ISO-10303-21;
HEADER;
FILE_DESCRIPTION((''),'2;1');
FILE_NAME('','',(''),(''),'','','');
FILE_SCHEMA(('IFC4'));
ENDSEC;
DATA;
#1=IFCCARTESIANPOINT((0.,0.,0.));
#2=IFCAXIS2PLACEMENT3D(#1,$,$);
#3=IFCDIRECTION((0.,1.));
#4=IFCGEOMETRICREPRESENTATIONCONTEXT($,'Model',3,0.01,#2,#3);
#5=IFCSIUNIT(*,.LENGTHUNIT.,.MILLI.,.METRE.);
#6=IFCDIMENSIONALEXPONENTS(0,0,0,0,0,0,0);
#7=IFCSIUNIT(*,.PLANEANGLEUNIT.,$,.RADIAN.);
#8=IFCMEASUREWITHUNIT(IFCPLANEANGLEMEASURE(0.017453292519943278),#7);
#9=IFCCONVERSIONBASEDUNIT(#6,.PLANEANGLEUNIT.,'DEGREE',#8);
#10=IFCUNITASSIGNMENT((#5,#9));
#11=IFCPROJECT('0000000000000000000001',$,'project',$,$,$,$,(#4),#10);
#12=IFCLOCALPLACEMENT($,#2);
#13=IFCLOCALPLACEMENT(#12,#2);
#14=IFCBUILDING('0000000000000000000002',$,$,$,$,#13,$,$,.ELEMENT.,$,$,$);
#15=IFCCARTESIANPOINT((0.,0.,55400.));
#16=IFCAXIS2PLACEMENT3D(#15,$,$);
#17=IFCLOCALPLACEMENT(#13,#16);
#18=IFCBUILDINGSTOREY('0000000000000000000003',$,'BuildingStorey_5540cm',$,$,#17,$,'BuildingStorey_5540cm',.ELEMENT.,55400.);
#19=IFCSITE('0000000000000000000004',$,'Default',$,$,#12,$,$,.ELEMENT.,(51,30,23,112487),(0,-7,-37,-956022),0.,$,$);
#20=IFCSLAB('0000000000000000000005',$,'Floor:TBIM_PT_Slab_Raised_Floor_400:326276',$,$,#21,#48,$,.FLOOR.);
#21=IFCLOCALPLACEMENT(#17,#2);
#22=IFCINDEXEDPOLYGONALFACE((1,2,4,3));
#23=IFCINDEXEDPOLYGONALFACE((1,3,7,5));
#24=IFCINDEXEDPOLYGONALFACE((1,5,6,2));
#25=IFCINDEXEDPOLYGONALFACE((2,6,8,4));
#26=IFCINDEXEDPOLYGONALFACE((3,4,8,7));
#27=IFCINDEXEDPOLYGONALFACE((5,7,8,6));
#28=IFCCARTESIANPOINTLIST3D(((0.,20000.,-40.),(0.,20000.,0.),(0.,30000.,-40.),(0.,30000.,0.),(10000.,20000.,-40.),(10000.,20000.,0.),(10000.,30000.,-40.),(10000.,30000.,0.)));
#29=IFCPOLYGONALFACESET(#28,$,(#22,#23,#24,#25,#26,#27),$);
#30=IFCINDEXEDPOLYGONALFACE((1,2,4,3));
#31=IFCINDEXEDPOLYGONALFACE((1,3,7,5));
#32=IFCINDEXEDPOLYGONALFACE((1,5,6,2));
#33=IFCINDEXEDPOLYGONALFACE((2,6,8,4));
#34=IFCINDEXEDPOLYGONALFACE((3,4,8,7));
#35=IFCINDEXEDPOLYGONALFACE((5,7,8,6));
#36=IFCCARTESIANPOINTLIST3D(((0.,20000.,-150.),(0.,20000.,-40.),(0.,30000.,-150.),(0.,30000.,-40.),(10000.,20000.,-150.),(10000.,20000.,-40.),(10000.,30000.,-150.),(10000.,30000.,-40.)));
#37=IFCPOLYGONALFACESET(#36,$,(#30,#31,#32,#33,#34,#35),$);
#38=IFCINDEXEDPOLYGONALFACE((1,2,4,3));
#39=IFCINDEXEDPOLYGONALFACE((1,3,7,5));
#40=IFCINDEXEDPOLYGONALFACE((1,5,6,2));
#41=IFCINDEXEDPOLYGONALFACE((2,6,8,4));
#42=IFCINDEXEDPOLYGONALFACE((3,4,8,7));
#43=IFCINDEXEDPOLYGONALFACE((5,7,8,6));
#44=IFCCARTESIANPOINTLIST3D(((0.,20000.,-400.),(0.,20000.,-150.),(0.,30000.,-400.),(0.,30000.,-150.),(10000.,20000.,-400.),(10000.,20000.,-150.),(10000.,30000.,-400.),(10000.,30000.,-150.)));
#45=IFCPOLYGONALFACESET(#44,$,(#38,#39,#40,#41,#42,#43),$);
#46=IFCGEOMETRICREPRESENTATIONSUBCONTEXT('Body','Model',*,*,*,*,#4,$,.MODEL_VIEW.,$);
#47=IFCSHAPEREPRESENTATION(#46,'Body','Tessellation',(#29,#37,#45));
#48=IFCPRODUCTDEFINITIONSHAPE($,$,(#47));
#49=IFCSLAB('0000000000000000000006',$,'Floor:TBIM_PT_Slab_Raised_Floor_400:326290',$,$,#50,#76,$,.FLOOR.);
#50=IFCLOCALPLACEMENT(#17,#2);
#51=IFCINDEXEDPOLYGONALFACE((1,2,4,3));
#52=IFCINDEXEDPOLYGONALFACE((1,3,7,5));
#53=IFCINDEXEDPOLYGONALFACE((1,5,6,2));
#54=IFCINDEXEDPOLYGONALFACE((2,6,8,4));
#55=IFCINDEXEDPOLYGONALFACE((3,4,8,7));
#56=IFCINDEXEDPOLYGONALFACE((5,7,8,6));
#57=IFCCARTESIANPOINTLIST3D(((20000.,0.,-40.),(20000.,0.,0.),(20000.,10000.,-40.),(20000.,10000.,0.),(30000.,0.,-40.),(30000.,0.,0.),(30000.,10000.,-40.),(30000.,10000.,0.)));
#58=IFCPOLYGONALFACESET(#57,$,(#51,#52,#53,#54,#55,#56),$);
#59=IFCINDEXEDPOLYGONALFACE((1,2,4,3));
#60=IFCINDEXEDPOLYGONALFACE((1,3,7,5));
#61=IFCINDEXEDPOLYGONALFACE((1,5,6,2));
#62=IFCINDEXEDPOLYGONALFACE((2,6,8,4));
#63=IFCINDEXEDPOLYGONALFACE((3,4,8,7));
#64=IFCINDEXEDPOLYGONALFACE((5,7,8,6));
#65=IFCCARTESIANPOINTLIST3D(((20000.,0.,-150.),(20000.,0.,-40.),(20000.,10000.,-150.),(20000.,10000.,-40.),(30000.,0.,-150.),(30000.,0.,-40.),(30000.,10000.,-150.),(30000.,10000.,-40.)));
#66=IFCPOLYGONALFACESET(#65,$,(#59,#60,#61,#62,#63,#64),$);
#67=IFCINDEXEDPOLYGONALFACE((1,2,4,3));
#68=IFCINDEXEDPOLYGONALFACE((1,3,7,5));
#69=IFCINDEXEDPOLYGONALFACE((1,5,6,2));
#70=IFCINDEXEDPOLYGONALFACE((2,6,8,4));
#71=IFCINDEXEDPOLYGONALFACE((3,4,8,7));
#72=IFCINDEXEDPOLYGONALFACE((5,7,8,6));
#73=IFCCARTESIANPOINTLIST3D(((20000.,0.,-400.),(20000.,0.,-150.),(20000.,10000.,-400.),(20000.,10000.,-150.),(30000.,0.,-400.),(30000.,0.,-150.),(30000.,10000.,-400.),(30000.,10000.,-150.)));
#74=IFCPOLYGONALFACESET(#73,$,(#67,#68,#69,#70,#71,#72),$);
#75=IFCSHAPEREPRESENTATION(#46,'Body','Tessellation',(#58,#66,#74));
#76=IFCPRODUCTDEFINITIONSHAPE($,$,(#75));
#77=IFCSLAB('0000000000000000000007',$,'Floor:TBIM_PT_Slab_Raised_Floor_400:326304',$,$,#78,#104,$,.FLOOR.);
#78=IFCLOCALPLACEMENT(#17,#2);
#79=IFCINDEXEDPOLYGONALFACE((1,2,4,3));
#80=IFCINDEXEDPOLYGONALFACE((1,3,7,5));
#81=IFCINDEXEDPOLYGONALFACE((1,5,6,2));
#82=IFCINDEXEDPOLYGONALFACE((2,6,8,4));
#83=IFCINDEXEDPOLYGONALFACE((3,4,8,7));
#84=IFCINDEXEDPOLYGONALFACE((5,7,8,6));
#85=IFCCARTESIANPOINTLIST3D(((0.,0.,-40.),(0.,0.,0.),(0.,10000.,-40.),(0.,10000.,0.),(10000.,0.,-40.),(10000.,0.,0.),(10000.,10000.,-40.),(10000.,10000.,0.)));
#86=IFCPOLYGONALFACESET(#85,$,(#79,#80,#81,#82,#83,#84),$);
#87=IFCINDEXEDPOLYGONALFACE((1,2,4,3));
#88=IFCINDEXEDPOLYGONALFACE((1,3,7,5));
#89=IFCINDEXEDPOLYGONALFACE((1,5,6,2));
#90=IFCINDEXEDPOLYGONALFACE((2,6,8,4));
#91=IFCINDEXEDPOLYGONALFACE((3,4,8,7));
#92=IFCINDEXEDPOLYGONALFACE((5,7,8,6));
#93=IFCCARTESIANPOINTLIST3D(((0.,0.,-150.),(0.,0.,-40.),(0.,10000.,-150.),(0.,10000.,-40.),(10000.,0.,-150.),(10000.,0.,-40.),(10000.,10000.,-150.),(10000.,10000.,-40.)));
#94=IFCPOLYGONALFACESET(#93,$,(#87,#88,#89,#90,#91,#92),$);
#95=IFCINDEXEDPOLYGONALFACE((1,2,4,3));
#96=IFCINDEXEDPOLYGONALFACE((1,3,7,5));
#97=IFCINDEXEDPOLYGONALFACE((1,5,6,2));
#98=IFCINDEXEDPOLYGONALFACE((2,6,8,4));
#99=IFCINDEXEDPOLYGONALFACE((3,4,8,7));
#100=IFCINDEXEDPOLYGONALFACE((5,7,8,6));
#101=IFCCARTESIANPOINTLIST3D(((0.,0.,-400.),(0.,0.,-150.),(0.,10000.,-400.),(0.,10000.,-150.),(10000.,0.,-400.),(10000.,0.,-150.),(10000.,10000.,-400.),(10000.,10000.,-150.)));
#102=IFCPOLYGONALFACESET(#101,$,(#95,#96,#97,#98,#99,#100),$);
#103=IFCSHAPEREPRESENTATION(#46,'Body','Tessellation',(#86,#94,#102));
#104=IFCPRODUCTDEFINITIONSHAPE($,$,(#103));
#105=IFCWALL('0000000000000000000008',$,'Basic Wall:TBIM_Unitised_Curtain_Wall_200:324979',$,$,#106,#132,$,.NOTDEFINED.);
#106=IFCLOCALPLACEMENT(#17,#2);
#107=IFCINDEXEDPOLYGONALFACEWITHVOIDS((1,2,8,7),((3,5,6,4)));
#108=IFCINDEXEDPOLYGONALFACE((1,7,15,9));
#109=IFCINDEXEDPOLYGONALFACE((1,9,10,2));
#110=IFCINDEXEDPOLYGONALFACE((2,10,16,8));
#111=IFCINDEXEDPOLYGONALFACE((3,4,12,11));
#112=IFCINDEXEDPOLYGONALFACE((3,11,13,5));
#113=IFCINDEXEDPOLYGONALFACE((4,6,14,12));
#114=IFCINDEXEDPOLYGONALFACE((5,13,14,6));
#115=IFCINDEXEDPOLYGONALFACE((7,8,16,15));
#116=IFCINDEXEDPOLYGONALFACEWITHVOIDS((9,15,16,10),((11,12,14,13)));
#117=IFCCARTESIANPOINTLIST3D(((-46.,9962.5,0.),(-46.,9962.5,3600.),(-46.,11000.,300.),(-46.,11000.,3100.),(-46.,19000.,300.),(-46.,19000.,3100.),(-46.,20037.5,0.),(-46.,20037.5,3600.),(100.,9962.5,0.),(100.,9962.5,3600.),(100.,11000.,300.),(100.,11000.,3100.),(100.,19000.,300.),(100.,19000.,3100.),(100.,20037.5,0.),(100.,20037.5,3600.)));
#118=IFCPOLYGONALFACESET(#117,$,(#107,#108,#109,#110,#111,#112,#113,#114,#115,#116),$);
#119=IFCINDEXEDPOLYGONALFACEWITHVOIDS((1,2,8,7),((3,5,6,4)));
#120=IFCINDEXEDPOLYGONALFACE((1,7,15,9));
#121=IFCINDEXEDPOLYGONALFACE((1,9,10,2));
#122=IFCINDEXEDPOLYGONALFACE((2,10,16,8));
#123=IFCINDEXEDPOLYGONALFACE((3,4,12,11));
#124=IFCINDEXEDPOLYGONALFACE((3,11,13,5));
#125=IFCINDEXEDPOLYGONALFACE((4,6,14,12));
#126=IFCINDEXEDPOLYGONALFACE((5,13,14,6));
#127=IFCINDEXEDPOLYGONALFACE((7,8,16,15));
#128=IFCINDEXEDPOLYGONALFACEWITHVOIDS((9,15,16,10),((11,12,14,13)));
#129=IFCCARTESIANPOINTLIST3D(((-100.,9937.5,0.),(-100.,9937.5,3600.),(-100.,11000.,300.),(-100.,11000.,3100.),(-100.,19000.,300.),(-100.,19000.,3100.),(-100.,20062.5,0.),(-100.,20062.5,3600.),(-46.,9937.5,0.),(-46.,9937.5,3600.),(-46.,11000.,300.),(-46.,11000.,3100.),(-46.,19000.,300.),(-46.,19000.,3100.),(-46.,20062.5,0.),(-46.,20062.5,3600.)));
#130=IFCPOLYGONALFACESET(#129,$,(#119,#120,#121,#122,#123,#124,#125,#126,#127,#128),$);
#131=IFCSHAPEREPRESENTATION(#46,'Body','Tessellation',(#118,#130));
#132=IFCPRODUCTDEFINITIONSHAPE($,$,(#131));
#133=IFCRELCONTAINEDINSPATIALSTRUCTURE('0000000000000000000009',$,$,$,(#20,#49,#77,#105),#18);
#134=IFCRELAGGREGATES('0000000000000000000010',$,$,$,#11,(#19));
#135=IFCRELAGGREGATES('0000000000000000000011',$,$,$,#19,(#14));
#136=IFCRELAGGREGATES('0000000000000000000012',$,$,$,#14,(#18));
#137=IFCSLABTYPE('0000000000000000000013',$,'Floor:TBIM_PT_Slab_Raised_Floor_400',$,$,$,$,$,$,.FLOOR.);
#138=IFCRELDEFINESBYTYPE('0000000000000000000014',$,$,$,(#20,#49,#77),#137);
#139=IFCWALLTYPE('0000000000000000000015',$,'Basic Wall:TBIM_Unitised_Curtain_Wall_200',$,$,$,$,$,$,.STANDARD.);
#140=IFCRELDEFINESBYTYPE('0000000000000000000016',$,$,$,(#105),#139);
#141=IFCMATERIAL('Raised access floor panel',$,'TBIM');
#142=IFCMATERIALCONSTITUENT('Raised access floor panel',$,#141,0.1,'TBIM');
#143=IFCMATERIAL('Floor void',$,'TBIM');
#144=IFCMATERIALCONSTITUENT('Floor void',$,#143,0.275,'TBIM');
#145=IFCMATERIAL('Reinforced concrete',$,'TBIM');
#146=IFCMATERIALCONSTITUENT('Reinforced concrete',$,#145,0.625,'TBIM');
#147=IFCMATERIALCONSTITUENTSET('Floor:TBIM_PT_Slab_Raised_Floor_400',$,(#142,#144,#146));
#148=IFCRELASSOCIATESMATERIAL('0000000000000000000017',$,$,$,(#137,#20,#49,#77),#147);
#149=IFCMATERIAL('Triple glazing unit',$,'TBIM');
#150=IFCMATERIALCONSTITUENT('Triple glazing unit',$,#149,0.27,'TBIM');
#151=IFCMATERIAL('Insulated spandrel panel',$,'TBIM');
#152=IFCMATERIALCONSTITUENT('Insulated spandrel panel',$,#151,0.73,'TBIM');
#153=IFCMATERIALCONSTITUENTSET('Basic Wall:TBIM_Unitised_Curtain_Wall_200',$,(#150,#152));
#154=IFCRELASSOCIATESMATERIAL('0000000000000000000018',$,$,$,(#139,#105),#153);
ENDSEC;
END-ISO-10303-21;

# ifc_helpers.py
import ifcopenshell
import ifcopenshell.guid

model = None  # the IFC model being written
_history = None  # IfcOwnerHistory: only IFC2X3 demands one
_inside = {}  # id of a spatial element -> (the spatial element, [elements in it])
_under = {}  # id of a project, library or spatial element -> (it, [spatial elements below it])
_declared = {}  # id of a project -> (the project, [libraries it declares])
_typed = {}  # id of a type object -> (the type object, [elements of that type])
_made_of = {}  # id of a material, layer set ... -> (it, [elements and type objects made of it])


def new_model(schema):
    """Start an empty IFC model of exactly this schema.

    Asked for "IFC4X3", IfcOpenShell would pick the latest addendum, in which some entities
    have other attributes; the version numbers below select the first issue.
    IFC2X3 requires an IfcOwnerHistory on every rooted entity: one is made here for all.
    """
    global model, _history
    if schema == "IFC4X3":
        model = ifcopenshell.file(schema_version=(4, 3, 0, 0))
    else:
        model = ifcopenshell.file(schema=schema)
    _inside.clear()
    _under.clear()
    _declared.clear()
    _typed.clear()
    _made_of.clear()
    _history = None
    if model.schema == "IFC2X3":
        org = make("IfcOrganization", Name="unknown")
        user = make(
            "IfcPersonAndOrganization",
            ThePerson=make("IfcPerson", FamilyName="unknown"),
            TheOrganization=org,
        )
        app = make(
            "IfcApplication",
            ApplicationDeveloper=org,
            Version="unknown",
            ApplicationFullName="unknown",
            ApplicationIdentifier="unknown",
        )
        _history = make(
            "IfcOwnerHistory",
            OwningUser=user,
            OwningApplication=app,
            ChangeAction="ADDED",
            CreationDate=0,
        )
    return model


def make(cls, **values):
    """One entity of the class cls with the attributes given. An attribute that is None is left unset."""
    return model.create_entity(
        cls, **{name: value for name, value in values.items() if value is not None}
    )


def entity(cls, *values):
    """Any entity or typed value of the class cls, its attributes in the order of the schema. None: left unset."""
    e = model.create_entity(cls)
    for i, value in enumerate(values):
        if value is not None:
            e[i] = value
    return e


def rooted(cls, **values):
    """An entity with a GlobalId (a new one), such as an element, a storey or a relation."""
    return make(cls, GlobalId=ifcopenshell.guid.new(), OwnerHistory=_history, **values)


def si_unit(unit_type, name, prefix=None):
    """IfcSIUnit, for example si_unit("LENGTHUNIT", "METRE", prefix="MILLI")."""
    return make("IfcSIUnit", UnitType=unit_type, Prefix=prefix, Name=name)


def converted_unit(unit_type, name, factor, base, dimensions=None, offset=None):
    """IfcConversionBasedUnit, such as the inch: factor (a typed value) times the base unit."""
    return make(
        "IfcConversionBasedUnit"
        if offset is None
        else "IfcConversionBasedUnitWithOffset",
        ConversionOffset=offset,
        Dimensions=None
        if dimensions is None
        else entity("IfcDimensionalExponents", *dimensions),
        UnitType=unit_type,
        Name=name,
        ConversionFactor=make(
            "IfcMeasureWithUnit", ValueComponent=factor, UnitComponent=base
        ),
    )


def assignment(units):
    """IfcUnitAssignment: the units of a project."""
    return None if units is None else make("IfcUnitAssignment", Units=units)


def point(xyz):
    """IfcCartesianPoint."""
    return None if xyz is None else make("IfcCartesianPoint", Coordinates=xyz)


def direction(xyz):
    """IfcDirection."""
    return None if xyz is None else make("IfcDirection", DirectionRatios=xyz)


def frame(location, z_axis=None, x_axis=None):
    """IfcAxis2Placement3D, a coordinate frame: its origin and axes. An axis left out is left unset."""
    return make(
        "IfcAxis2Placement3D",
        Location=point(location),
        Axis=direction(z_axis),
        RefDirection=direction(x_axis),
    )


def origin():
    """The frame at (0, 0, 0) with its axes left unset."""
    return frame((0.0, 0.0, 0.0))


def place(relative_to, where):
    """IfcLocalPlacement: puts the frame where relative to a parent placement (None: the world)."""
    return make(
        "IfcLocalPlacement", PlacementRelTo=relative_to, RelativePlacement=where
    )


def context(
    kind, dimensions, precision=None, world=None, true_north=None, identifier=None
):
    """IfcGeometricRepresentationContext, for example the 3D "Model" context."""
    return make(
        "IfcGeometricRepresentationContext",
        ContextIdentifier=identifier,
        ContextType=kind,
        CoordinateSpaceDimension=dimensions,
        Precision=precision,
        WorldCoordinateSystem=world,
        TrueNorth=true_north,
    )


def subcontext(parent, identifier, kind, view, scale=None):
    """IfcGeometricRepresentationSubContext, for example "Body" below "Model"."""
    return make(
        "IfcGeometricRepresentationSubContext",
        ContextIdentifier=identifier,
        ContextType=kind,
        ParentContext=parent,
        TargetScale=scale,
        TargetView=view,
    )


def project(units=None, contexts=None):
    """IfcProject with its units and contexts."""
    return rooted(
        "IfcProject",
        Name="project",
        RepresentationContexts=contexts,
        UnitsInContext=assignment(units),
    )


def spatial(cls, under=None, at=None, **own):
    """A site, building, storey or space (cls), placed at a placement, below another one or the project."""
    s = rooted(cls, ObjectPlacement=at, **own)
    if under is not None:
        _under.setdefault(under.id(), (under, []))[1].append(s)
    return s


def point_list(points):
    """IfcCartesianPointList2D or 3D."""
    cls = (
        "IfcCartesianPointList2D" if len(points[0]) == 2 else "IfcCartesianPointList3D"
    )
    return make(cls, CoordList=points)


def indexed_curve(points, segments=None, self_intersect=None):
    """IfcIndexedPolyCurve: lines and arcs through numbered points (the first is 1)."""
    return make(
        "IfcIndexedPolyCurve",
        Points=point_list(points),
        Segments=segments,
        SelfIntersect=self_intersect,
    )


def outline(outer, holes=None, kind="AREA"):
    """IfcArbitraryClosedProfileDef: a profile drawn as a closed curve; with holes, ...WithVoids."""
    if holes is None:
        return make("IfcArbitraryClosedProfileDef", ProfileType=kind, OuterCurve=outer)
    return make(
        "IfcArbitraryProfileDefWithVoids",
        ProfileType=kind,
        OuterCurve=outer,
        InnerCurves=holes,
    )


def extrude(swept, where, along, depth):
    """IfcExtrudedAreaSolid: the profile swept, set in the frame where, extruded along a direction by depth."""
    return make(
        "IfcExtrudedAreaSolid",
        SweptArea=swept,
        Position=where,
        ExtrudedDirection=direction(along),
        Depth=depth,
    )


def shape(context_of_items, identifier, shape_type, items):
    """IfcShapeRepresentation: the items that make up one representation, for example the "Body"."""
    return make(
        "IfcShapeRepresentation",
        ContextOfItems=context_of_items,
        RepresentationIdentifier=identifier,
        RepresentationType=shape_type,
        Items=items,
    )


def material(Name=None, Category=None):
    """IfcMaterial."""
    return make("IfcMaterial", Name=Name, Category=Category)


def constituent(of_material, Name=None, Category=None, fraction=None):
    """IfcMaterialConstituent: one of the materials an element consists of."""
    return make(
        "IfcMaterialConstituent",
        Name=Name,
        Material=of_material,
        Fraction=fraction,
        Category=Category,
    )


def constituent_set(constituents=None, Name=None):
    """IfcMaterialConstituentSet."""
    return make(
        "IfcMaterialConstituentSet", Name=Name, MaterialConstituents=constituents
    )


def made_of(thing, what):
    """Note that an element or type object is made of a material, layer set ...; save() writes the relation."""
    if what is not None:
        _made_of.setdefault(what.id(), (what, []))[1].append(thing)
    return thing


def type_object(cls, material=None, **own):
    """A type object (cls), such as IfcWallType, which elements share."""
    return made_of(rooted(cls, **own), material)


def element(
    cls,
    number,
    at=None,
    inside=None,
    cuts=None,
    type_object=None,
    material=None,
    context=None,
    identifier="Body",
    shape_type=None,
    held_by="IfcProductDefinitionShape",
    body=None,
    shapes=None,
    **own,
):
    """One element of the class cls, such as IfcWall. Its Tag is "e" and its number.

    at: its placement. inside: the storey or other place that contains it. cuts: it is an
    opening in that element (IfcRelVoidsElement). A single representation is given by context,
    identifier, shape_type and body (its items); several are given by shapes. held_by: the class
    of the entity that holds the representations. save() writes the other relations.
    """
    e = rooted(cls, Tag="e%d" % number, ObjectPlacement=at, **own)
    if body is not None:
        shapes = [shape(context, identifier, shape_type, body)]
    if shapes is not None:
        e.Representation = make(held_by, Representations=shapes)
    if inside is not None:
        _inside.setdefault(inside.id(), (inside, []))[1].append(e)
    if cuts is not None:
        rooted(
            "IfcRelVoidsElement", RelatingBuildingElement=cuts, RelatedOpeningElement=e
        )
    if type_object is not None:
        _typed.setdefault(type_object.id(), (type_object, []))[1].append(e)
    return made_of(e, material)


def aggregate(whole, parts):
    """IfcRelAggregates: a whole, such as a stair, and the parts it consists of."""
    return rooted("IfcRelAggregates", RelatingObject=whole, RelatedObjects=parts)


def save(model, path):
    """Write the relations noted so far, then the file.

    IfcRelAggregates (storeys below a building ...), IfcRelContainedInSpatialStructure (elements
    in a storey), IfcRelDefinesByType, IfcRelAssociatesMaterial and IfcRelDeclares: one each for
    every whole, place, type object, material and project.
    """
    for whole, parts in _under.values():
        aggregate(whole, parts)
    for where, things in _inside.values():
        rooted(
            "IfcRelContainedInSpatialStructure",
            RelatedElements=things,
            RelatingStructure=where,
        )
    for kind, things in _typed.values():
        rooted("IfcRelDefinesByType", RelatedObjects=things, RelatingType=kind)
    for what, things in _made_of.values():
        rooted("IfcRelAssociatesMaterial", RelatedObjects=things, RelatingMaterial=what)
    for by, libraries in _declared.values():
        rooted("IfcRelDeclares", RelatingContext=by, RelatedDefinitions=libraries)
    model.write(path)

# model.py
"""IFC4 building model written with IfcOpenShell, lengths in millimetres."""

from ifc_helpers import new_model, entity, si_unit, converted_unit, direction, frame, origin, place, context, subcontext, project, spatial, indexed_curve, outline, extrude, material, constituent, constituent_set, type_object, element, save


model = new_model("IFC4")

# Units and contexts
model_context = context("Model", 3, precision=0.01, world=origin(), true_north=direction((0.0, 1.0)))
body_context = subcontext(model_context, "Body", "Model", "MODEL_VIEW")
ifc_project = project(units=[si_unit("LENGTHUNIT", "METRE", prefix="MILLI"), converted_unit("PLANEANGLEUNIT", "DEGREE", entity("IfcPlaneAngleMeasure", 0.017453292519943278), si_unit("PLANEANGLEUNIT", "RADIAN"), dimensions=[0, 0, 0, 0, 0, 0, 0])], contexts=[model_context])

# Site, building, storey
site_placement = place(None, origin())
site = spatial("IfcSite", under=ifc_project, at=site_placement, Name="Default", CompositionType="ELEMENT", RefLatitude=(51, 30, 23, 112487), RefLongitude=(0, -7, -37, -956022), RefElevation=0.0)
building_placement = place(site_placement, origin())
building = spatial("IfcBuilding", under=site, at=building_placement, CompositionType="ELEMENT")
storey_placement = place(building_placement, frame((0.0, 0.0, 55400.0)))
storey = spatial("IfcBuildingStorey", under=building, at=storey_placement, Name="BuildingStorey_5540cm", LongName="BuildingStorey_5540cm", CompositionType="ELEMENT", Elevation=55400.0)

# Slabs
ifc_material_1 = material(Name="Raised access floor panel", Category="TBIM")
ifc_constituent_1 = constituent(ifc_material_1, Name="Raised access floor panel", Category="TBIM", fraction=0.1)
ifc_material_2 = material(Name="Floor void", Category="TBIM")
ifc_constituent_2 = constituent(ifc_material_2, Name="Floor void", Category="TBIM", fraction=0.275)
ifc_material_3 = material(Name="Reinforced concrete", Category="TBIM")
ifc_constituent_3 = constituent(ifc_material_3, Name="Reinforced concrete", Category="TBIM", fraction=0.625)
ifc_constituent_set_1 = constituent_set(constituents=[ifc_constituent_1, ifc_constituent_2, ifc_constituent_3], Name="Floor:TBIM_PT_Slab_Raised_Floor_400")
slab_type = type_object("IfcSlabType", Name="Floor:TBIM_PT_Slab_Raised_Floor_400", PredefinedType="FLOOR", material=ifc_constituent_set_1)
slab_1_placement = place(storey_placement, origin())
element("IfcSlab", 1, at=slab_1_placement, inside=storey, type_object=slab_type, material=ifc_constituent_set_1, Name="Floor:TBIM_PT_Slab_Raised_Floor_400:326276", PredefinedType="FLOOR", context=body_context, shape_type="SweptSolid", body=[
    extrude(outline(indexed_curve([(-5000.0, -5000.0), (5000.0, -5000.0), (5000.0, 5000.0), (-5000.0, 5000.0), (-5000.0, -5000.0)], self_intersect=False)), frame((5000.0, 25000.0, -40.0), z_axis=(0.0, 0.0, 1.0), x_axis=(-1.0, 0.0, 0.0)), (0.0, 0.0, 1.0), 40.0),
    extrude(outline(indexed_curve([(-5000.0, -5000.0), (5000.0, -5000.0), (5000.0, 5000.0), (-5000.0, 5000.0), (-5000.0, -5000.0)], self_intersect=False)), frame((5000.0, 25000.0, -150.0), z_axis=(0.0, 0.0, 1.0), x_axis=(-1.0, 0.0, 0.0)), (0.0, 0.0, 1.0), 110.0),
    extrude(outline(indexed_curve([(-5000.0, -5000.0), (5000.0, -5000.0), (5000.0, 5000.0), (-5000.0, 5000.0), (-5000.0, -5000.0)], self_intersect=False)), frame((5000.0, 25000.0, -400.0), z_axis=(0.0, 0.0, 1.0), x_axis=(-1.0, 0.0, 0.0)), (0.0, 0.0, 1.0), 250.0),
])
slab_2_placement = place(storey_placement, origin())
element("IfcSlab", 2, at=slab_2_placement, inside=storey, type_object=slab_type, material=ifc_constituent_set_1, Name="Floor:TBIM_PT_Slab_Raised_Floor_400:326290", PredefinedType="FLOOR", context=body_context, shape_type="SweptSolid", body=[
    extrude(outline(indexed_curve([(-5000.0, -5000.0), (5000.0, -5000.0), (5000.0, 5000.0), (-5000.0, 5000.0), (-5000.0, -5000.0)], self_intersect=False)), frame((25000.0, 5000.0, -40.0), z_axis=(0.0, 0.0, 1.0), x_axis=(-1.0, 0.0, 0.0)), (0.0, 0.0, 1.0), 40.0),
    extrude(outline(indexed_curve([(-5000.0, -5000.0), (5000.0, -5000.0), (5000.0, 5000.0), (-5000.0, 5000.0), (-5000.0, -5000.0)], self_intersect=False)), frame((25000.0, 5000.0, -150.0), z_axis=(0.0, 0.0, 1.0), x_axis=(-1.0, 0.0, 0.0)), (0.0, 0.0, 1.0), 110.0),
    extrude(outline(indexed_curve([(-5000.0, -5000.0), (5000.0, -5000.0), (5000.0, 5000.0), (-5000.0, 5000.0), (-5000.0, -5000.0)], self_intersect=False)), frame((25000.0, 5000.0, -400.0), z_axis=(0.0, 0.0, 1.0), x_axis=(-1.0, 0.0, 0.0)), (0.0, 0.0, 1.0), 250.0),
])
slab_3_placement = place(storey_placement, origin())
element("IfcSlab", 3, at=slab_3_placement, inside=storey, type_object=slab_type, material=ifc_constituent_set_1, Name="Floor:TBIM_PT_Slab_Raised_Floor_400:326304", PredefinedType="FLOOR", context=body_context, shape_type="SweptSolid", body=[
    extrude(outline(indexed_curve([(-5000.0, -5000.0), (5000.0, -5000.0), (5000.0, 5000.0), (-5000.0, 5000.0), (-5000.0, -5000.0)], self_intersect=False)), frame((5000.0, 5000.0, -40.0), z_axis=(0.0, 0.0, 1.0), x_axis=(-1.0, 0.0, 0.0)), (0.0, 0.0, 1.0), 40.0),
    extrude(outline(indexed_curve([(-5000.0, -5000.0), (5000.0, -5000.0), (5000.0, 5000.0), (-5000.0, 5000.0), (-5000.0, -5000.0)], self_intersect=False)), frame((5000.0, 5000.0, -150.0), z_axis=(0.0, 0.0, 1.0), x_axis=(-1.0, 0.0, 0.0)), (0.0, 0.0, 1.0), 110.0),
    extrude(outline(indexed_curve([(-5000.0, -5000.0), (5000.0, -5000.0), (5000.0, 5000.0), (-5000.0, 5000.0), (-5000.0, -5000.0)], self_intersect=False)), frame((5000.0, 5000.0, -400.0), z_axis=(0.0, 0.0, 1.0), x_axis=(-1.0, 0.0, 0.0)), (0.0, 0.0, 1.0), 250.0),
])

# Wall, opening
ifc_material_4 = material(Name="Triple glazing unit", Category="TBIM")
ifc_constituent_4 = constituent(ifc_material_4, Name="Triple glazing unit", Category="TBIM", fraction=0.27)
ifc_material_5 = material(Name="Insulated spandrel panel", Category="TBIM")
ifc_constituent_5 = constituent(ifc_material_5, Name="Insulated spandrel panel", Category="TBIM", fraction=0.73)
ifc_constituent_set_2 = constituent_set(constituents=[ifc_constituent_4, ifc_constituent_5], Name="Basic Wall:TBIM_Unitised_Curtain_Wall_200")
wall_type = type_object("IfcWallType", Name="Basic Wall:TBIM_Unitised_Curtain_Wall_200", PredefinedType="STANDARD", material=ifc_constituent_set_2)
wall_1_placement = place(storey_placement, frame((0.0, 9937.5, 0.0), z_axis=(0.0, 0.0, 1.0), x_axis=(0.0, 1.0, 0.0)))
wall_1 = element("IfcWall", 4, at=wall_1_placement, inside=storey, type_object=wall_type, material=ifc_constituent_set_2, Name="Basic Wall:TBIM_Unitised_Curtain_Wall_200:324979", PredefinedType="NOTDEFINED", context=body_context, shape_type="SweptSolid", body=[
    extrude(outline(indexed_curve([(-1800.0, -5037.5), (1800.0, -5037.5), (1800.0, 5037.5), (-1800.0, 5037.5), (-1800.0, -5037.5)], self_intersect=False), holes=[indexed_curve([(1300.0, 4000.0), (1300.0, -4000.0), (-1500.0, -4000.0), (-1500.0, 4000.0), (1300.0, 4000.0)], self_intersect=False)]), frame((5062.5, 46.0, 1800.0), z_axis=(0.0, -1.0, 0.0), x_axis=(0.0, 0.0, 1.0)), (0.0, 0.0, 1.0), 146.0),
    extrude(outline(indexed_curve([(-5062.5, -1800.0), (5062.5, -1800.0), (5062.5, 1800.0), (-5062.5, 1800.0), (-5062.5, -1800.0)], self_intersect=False), holes=[indexed_curve([(-4000.0, 1300.0), (4000.0, 1300.0), (4000.0, -1500.0), (-4000.0, -1500.0), (-4000.0, 1300.0)], self_intersect=False)]), frame((5062.5, 100.0, 1800.0), z_axis=(0.0, -1.0, 0.0), x_axis=(1.0, 0.0, 0.0)), (0.0, 0.0, 1.0), 54.0),
])
opening_1_placement = place(wall_1_placement, frame((1062.5, -100.0, 300.0)))
element("IfcOpeningElement", 5, at=opening_1_placement, cuts=wall_1, PredefinedType="OPENING", context=body_context, shape_type="SweptSolid", body=[
    extrude(outline(indexed_curve([(2800.0, 0.0), (2800.0, 8000.0), (0.0, 8000.0), (0.0, 0.0), (2800.0, 0.0)], self_intersect=False)), frame((0.0, 0.0, 0.0), z_axis=(0.0, 1.0, 0.0), x_axis=(0.0, 0.0, 1.0)), (0.0, 0.0, 1.0), 200.0),
])

save(model, "model.ifc")
